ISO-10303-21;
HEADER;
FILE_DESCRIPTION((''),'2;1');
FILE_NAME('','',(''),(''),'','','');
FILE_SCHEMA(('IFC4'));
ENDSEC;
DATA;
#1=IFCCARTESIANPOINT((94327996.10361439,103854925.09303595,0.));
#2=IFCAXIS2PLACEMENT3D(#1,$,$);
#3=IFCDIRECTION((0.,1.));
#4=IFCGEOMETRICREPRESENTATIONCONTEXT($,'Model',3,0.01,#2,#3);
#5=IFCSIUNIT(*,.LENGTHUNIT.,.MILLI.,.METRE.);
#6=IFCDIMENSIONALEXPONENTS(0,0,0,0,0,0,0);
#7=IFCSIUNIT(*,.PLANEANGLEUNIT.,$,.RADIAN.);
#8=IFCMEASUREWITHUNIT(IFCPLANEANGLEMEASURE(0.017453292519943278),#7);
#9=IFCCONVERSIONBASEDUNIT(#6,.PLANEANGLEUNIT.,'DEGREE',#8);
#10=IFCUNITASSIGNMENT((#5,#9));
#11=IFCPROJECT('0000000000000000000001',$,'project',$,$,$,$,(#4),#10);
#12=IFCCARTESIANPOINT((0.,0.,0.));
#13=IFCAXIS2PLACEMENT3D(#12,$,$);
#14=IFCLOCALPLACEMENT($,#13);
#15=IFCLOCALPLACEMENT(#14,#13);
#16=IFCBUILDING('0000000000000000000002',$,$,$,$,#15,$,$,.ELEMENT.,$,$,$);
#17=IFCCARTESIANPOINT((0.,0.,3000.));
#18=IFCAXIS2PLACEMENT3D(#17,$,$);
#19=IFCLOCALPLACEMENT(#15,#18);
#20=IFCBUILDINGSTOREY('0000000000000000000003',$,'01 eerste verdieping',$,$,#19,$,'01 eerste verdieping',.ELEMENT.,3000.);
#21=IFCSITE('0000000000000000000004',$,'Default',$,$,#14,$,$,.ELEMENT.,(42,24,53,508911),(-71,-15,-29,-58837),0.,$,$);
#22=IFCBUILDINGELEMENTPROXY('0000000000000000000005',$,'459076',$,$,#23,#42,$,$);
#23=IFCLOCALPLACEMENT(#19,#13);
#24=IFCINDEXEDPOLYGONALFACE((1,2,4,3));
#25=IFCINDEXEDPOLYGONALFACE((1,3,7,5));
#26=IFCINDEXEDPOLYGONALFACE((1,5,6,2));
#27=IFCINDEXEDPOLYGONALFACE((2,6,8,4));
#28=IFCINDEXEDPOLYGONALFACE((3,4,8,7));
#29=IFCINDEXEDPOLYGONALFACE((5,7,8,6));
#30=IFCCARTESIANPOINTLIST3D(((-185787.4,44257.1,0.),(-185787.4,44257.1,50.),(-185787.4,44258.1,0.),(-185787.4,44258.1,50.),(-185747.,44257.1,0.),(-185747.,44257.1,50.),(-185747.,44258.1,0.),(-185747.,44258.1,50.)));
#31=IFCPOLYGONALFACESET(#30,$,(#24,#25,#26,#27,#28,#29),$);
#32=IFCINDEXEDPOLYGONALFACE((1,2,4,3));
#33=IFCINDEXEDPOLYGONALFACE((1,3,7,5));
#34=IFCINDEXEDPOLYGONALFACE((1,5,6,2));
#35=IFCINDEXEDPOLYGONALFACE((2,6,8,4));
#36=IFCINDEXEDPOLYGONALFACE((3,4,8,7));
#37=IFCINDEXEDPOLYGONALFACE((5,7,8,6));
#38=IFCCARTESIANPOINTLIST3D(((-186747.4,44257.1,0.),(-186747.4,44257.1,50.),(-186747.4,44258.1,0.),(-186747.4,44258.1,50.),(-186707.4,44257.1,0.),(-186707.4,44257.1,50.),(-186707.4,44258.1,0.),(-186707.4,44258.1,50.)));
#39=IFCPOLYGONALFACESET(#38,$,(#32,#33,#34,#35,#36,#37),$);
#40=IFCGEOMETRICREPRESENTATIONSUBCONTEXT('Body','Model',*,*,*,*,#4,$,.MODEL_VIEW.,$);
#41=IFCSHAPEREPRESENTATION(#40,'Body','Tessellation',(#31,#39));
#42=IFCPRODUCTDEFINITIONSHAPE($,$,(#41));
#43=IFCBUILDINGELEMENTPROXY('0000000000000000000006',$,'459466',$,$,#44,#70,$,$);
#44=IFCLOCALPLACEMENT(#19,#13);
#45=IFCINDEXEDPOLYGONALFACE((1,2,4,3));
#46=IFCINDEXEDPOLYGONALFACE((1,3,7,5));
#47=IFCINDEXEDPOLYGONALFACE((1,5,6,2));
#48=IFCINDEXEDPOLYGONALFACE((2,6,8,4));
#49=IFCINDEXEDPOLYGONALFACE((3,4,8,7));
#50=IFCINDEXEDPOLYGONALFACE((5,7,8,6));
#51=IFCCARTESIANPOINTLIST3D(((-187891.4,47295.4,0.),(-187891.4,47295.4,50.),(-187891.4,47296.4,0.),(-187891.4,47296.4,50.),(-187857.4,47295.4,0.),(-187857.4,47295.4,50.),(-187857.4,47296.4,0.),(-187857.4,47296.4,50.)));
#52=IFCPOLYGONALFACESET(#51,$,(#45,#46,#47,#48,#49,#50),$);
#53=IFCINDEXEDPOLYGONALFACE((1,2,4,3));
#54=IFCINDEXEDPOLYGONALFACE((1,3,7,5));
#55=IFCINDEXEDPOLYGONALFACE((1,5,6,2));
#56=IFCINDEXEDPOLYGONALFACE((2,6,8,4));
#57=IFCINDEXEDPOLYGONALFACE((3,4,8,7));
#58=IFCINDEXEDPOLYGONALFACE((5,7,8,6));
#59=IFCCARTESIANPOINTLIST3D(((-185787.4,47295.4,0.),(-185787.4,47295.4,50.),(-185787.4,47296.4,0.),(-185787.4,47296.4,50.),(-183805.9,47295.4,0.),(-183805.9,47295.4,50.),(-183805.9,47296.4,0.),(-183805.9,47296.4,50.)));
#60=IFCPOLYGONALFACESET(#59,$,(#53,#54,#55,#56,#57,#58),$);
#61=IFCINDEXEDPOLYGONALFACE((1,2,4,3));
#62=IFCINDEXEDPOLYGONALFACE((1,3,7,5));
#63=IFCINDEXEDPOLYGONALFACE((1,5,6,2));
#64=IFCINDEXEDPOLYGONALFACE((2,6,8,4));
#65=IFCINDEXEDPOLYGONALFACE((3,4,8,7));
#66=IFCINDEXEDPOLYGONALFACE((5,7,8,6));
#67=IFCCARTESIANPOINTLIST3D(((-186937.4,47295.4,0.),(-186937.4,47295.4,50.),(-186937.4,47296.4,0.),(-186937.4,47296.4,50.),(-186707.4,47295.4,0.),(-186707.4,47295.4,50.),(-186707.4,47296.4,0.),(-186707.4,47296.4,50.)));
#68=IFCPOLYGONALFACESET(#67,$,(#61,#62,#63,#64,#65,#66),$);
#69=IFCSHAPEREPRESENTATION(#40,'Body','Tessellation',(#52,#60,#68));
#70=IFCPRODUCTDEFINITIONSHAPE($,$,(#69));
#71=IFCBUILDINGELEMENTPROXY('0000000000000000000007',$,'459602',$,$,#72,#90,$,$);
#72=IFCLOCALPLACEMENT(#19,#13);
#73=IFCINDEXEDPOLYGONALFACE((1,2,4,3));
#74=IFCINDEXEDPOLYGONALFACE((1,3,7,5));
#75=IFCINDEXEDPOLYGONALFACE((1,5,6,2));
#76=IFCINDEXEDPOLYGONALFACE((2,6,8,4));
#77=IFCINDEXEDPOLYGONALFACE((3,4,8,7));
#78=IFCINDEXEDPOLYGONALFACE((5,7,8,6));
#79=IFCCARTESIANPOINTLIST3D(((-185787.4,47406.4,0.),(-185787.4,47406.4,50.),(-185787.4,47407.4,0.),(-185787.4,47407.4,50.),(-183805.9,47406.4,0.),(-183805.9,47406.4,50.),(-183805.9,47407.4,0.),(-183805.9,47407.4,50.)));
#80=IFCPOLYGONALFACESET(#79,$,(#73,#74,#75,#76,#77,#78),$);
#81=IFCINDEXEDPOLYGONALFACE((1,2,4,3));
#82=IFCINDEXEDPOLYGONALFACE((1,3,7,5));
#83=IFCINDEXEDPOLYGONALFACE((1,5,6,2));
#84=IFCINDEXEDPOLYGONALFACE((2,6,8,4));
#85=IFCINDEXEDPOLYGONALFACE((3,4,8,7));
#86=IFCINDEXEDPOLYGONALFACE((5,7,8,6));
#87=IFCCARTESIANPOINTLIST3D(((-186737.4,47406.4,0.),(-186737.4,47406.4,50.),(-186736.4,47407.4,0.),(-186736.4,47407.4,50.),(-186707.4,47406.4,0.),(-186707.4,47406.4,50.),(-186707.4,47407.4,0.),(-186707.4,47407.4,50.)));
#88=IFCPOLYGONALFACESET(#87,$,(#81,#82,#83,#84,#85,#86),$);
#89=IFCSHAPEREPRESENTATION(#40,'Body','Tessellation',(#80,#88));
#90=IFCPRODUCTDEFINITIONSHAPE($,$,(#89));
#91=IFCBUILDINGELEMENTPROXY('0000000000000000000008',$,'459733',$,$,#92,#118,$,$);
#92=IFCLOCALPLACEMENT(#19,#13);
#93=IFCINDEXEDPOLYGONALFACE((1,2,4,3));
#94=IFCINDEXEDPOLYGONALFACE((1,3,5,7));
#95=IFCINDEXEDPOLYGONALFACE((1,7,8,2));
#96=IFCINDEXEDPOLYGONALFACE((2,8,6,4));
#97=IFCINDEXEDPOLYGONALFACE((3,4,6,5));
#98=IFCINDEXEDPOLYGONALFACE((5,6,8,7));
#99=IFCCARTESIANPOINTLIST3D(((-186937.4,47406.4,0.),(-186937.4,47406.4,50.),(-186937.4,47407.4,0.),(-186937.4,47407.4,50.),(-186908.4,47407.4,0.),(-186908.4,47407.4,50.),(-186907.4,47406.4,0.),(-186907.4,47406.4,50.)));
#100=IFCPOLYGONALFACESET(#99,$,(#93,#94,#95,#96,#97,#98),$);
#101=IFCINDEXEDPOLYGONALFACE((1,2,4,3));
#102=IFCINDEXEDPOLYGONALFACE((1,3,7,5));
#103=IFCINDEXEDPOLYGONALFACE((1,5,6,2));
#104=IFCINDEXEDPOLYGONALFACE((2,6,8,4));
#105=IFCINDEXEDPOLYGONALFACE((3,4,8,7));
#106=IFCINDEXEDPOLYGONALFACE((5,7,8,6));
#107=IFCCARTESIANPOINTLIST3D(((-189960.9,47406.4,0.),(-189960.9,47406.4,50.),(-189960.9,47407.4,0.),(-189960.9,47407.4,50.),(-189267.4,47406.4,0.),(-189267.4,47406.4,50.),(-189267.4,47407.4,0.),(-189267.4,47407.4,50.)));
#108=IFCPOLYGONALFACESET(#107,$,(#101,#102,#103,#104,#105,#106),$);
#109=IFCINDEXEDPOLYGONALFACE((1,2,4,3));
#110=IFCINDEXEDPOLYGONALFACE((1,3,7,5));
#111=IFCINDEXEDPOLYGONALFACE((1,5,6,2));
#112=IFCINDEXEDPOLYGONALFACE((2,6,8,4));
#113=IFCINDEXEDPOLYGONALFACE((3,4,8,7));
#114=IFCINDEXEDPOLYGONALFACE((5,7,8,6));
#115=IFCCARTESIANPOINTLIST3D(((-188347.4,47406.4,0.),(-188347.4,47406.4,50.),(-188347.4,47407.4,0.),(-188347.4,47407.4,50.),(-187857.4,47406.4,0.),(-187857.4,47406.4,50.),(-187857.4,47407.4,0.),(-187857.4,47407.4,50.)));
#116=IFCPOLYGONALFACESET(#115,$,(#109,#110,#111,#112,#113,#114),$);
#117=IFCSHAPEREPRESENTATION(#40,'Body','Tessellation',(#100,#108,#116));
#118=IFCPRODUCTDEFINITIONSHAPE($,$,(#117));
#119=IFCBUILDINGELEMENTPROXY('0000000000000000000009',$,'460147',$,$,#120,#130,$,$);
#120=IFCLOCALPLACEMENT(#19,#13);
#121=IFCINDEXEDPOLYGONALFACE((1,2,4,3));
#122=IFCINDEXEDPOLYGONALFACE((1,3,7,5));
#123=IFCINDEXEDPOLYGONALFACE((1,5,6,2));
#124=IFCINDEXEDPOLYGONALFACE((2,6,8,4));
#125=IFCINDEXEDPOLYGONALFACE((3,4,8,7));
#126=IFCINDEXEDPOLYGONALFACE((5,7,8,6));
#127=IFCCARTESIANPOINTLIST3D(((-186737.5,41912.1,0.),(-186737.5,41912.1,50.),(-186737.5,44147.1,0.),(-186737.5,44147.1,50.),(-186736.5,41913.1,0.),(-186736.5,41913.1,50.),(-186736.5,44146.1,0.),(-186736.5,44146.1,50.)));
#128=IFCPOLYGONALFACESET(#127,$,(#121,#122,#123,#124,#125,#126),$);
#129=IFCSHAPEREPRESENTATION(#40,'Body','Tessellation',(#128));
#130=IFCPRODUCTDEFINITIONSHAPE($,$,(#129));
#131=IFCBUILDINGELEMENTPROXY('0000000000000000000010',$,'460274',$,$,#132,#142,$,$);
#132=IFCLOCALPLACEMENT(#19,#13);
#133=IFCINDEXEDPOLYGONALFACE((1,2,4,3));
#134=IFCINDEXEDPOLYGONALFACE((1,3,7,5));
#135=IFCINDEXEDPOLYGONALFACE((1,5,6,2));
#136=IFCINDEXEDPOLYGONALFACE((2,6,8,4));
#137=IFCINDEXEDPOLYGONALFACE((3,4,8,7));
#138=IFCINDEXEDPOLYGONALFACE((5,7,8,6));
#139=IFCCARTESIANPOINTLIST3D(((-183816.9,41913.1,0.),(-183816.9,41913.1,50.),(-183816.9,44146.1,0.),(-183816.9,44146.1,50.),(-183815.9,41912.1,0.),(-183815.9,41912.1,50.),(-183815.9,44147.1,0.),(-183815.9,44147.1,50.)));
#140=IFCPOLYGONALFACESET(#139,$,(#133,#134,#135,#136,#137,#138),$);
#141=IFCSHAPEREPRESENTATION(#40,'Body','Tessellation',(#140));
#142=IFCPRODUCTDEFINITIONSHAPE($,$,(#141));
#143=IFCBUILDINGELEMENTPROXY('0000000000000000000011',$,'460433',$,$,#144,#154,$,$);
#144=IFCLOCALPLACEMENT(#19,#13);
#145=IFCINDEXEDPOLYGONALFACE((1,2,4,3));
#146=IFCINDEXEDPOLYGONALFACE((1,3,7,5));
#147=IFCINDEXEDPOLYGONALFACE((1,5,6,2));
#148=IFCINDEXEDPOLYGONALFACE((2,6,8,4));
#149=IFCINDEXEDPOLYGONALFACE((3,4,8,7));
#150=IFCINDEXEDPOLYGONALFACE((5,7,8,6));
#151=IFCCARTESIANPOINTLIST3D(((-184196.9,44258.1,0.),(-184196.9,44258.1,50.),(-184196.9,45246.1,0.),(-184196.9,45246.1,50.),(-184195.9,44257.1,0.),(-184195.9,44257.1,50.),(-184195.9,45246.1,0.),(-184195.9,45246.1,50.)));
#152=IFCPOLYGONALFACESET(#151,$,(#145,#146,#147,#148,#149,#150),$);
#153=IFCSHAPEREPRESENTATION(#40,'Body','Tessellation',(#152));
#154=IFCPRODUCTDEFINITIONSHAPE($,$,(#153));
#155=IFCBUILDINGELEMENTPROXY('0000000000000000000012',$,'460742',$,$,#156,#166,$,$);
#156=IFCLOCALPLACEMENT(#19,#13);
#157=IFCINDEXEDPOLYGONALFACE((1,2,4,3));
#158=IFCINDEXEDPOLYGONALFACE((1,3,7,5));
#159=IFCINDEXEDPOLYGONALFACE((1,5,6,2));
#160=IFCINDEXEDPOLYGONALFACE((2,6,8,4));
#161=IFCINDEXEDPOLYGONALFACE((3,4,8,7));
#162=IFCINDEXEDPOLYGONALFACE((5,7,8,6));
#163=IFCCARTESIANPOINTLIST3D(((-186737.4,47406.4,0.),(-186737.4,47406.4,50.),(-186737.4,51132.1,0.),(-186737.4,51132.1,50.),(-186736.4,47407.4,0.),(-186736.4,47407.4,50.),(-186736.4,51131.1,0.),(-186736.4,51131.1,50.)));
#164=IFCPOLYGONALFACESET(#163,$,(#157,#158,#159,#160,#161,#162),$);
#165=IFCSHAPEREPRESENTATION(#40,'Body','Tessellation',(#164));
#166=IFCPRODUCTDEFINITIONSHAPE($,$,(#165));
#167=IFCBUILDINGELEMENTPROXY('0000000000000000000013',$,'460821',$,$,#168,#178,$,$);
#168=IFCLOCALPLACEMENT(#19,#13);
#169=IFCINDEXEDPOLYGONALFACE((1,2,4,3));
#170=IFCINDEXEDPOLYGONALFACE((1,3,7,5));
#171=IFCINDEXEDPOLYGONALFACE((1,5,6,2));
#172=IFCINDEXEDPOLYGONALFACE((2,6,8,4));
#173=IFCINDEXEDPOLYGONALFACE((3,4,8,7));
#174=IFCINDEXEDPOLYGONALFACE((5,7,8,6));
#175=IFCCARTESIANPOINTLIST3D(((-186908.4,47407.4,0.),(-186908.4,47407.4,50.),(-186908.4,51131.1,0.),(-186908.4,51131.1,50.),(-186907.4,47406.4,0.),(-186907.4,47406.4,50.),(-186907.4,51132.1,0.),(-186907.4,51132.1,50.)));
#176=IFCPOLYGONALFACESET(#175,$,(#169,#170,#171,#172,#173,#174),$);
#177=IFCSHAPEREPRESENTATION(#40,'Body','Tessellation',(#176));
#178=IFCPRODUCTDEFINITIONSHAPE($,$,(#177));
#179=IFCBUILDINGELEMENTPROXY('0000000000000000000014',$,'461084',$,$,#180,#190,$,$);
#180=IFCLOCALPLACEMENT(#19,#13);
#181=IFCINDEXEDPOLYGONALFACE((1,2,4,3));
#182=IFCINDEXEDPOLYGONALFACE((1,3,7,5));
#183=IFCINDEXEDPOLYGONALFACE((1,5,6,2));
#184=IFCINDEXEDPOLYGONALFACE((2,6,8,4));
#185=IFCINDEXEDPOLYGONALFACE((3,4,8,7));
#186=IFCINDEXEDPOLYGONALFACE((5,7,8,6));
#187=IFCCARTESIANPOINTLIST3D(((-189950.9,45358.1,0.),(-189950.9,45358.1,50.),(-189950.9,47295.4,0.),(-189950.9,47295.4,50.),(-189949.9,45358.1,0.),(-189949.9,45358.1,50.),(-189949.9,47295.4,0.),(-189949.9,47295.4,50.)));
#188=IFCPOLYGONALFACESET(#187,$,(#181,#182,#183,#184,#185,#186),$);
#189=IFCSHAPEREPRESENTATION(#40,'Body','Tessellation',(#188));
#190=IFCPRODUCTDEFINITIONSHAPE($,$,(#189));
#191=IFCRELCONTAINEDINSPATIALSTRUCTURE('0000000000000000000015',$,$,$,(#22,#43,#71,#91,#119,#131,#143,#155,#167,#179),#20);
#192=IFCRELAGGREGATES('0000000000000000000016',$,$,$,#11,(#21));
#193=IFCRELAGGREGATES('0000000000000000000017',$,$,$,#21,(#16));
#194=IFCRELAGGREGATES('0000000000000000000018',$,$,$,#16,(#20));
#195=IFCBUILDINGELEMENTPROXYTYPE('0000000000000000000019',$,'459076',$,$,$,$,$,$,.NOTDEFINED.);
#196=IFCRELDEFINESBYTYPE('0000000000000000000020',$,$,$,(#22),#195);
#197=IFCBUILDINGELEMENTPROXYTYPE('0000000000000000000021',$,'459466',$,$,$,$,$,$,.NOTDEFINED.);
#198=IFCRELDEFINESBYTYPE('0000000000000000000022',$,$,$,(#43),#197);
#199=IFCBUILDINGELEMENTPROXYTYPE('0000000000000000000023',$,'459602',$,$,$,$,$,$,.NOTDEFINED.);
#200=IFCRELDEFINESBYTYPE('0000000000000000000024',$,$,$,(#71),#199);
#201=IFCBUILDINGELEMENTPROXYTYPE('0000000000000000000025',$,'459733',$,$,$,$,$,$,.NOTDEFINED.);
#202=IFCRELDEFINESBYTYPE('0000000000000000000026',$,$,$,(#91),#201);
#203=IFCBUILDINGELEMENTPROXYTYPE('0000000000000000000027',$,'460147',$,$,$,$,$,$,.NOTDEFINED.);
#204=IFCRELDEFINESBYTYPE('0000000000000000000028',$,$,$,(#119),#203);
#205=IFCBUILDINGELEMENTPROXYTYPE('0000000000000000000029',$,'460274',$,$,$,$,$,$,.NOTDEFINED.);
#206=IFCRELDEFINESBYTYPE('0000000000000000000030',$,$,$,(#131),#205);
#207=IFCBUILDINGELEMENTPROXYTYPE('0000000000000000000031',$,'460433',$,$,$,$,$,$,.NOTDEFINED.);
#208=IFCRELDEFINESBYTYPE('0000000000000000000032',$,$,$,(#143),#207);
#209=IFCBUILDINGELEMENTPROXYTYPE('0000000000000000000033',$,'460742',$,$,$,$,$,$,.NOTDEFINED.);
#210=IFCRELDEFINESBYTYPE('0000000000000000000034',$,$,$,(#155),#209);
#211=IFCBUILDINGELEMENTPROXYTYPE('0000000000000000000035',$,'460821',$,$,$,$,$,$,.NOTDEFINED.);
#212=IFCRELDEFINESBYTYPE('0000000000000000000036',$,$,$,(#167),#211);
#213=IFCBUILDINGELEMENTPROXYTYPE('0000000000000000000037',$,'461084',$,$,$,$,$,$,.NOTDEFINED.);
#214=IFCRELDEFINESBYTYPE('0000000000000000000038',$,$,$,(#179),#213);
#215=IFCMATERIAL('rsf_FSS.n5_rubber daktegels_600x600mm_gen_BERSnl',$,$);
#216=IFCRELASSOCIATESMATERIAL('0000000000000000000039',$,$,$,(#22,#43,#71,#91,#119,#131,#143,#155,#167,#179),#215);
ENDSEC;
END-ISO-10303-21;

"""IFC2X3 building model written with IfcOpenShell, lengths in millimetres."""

from ifc_helpers import new_model, entity, si_unit, converted_unit, direction, frame, frame_2d, origin, origin_2d_with_axis, place, context, subcontext, project, spatial, polyline, rectangle, outline, extrude, material, type_object, element, save


model = new_model("IFC2X3")

# Units and contexts
model_context = context("Model", 3, precision=0.01, world=frame((94327996.10361439, 103854925.09303595, 0.0)), true_north=direction((0.0, 1.0)))
body_context = subcontext(model_context, "Body", "Model", "MODEL_VIEW")
ifc_project = project(units=[si_unit("LENGTHUNIT", "METRE", prefix="MILLI"), converted_unit("PLANEANGLEUNIT", "DEGREE", entity("IfcPlaneAngleMeasure", 0.017453292519943278), si_unit("PLANEANGLEUNIT", "RADIAN"), dimensions=[0, 0, 0, 0, 0, 0, 0])], contexts=[model_context])

# Site, building, storey
site_placement = place(None, origin())
site = spatial("IfcSite", under=ifc_project, at=site_placement, Name="Default", CompositionType="ELEMENT", RefLatitude=(42, 24, 53, 508911), RefLongitude=(-71, -15, -29, -58837), RefElevation=0.0)
building_placement = place(site_placement, origin())
building = spatial("IfcBuilding", under=site, at=building_placement, CompositionType="ELEMENT")
storey_placement = place(building_placement, frame((0.0, 0.0, 3000.0)))
storey = spatial("IfcBuildingStorey", under=building, at=storey_placement, Name="01 eerste verdieping", LongName="01 eerste verdieping", CompositionType="ELEMENT", Elevation=3000.0)

# Building element proxies
ifc_material = material(Name="rsf_FSS.n5_rubber daktegels_600x600mm_gen_BERSnl")
building_element_proxy_type_1 = type_object("IfcBuildingElementProxyType", Name="459076", PredefinedType="NOTDEFINED")
proxy_1_placement = place(storey_placement, origin())
element("IfcBuildingElementProxy", 1, at=proxy_1_placement, inside=storey, type_object=building_element_proxy_type_1, material=ifc_material, Name="459076", context=body_context, shape_type="SweptSolid", body=[
    extrude(rectangle(XDim=40.4, YDim=1.0, at=frame_2d((0.0, 0.0), x_axis=(1.0, 0.0))), frame((-185767.2, 44257.6, 0.0)), (0.0, 0.0, 1.0), 50.0),
    extrude(rectangle(XDim=40.0, YDim=1.0, at=frame_2d((0.0, 0.0), x_axis=(1.0, 0.0))), frame((-186727.4, 44257.6, 0.0)), (0.0, 0.0, 1.0), 50.0),
])
building_element_proxy_type_2 = type_object("IfcBuildingElementProxyType", Name="459466", PredefinedType="NOTDEFINED")
proxy_2_placement = place(storey_placement, origin())
element("IfcBuildingElementProxy", 2, at=proxy_2_placement, inside=storey, type_object=building_element_proxy_type_2, material=ifc_material, Name="459466", context=body_context, shape_type="SweptSolid", body=[
    extrude(rectangle(XDim=34.0, YDim=1.0, at=frame_2d((0.0, 0.0), x_axis=(1.0, 0.0))), frame((-187874.4, 47295.9, 0.0), z_axis=(0.0, 0.0, 1.0), x_axis=(-1.0, 0.0, 0.0)), (0.0, 0.0, 1.0), 50.0),
    extrude(rectangle(XDim=1981.5, YDim=1.0, at=frame_2d((0.0, 0.0), x_axis=(1.0, 0.0))), frame((-184796.6, 47295.9, 0.0), z_axis=(0.0, 0.0, 1.0), x_axis=(-1.0, 0.0, 0.0)), (0.0, 0.0, 1.0), 50.0),
    extrude(rectangle(XDim=230.0, YDim=1.0, at=frame_2d((0.0, 0.0), x_axis=(1.0, 0.0))), frame((-186822.4, 47295.9, 0.0), z_axis=(0.0, 0.0, 1.0), x_axis=(-1.0, 0.0, 0.0)), (0.0, 0.0, 1.0), 50.0),
])
building_element_proxy_type_3 = type_object("IfcBuildingElementProxyType", Name="459602", PredefinedType="NOTDEFINED")
proxy_3_placement = place(storey_placement, origin())
element("IfcBuildingElementProxy", 3, at=proxy_3_placement, inside=storey, type_object=building_element_proxy_type_3, material=ifc_material, Name="459602", context=body_context, shape_type="SweptSolid", body=[
    extrude(rectangle(XDim=1981.5, YDim=1.0, at=frame_2d((0.0, 0.0), x_axis=(1.0, 0.0))), frame((-184796.6, 47406.9, 0.0)), (0.0, 0.0, 1.0), 50.0),
    extrude(outline(polyline([(-15.3, -0.5), (14.8, -0.5), (14.8, 0.5), (-14.3, 0.5), (-15.3, -0.5)])), frame((-186722.1, 47406.9, 0.0)), (0.0, 0.0, 1.0), 50.0),
])
building_element_proxy_type_4 = type_object("IfcBuildingElementProxyType", Name="459733", PredefinedType="NOTDEFINED")
proxy_4_placement = place(storey_placement, origin())
element("IfcBuildingElementProxy", 4, at=proxy_4_placement, inside=storey, type_object=building_element_proxy_type_4, material=ifc_material, Name="459733", context=body_context, shape_type="SweptSolid", body=[
    extrude(outline(polyline([(-14.7, -0.5), (15.2, -0.5), (14.2, 0.5), (-14.7, 0.5), (-14.7, -0.5)])), frame((-186922.6, 47406.9, 0.0)), (0.0, 0.0, 1.0), 50.0),
    extrude(rectangle(XDim=693.5, YDim=1.0, at=origin_2d_with_axis()), frame((-189614.1, 47406.9, 0.0)), (0.0, 0.0, 1.0), 50.0),
    extrude(rectangle(XDim=490.0, YDim=1.0, at=origin_2d_with_axis()), frame((-188102.4, 47406.9, 0.0)), (0.0, 0.0, 1.0), 50.0),
])
building_element_proxy_type_5 = type_object("IfcBuildingElementProxyType", Name="460147", PredefinedType="NOTDEFINED")
proxy_5_placement = place(storey_placement, origin())
element("IfcBuildingElementProxy", 5, at=proxy_5_placement, inside=storey, type_object=building_element_proxy_type_5, material=ifc_material, Name="460147", context=body_context, shape_type="SweptSolid", body=[
    extrude(outline(polyline([(-1117.5, -0.5), (1117.5, -0.5), (1116.5, 0.5), (-1116.5, 0.5), (-1117.5, -0.5)])), frame((-186737.0, 43029.6, 0.0), z_axis=(0.0, 0.0, 1.0), x_axis=(0.0, -1.0, 0.0)), (0.0, 0.0, 1.0), 50.0),
])
building_element_proxy_type_6 = type_object("IfcBuildingElementProxyType", Name="460274", PredefinedType="NOTDEFINED")
proxy_6_placement = place(storey_placement, origin())
element("IfcBuildingElementProxy", 6, at=proxy_6_placement, inside=storey, type_object=building_element_proxy_type_6, material=ifc_material, Name="460274", context=body_context, shape_type="SweptSolid", body=[
    extrude(outline(polyline([(-1117.5, -0.5), (1117.5, -0.5), (1116.5, 0.5), (-1116.5, 0.5), (-1117.5, -0.5)])), frame((-183816.4, 43029.6, 0.0), z_axis=(0.0, 0.0, 1.0), x_axis=(0.0, 1.0, 0.0)), (0.0, 0.0, 1.0), 50.0),
])
building_element_proxy_type_7 = type_object("IfcBuildingElementProxyType", Name="460433", PredefinedType="NOTDEFINED")
proxy_7_placement = place(storey_placement, origin())
element("IfcBuildingElementProxy", 7, at=proxy_7_placement, inside=storey, type_object=building_element_proxy_type_7, material=ifc_material, Name="460433", context=body_context, shape_type="SweptSolid", body=[
    extrude(outline(polyline([(-494.7, -0.5), (494.2, -0.5), (494.2, 0.5), (-493.7, 0.5), (-494.7, -0.5)])), frame((-184196.4, 44751.8, 0.0), z_axis=(0.0, 0.0, 1.0), x_axis=(0.0, 1.0, 0.0)), (0.0, 0.0, 1.0), 50.0),
])
building_element_proxy_type_8 = type_object("IfcBuildingElementProxyType", Name="460742", PredefinedType="NOTDEFINED")
proxy_8_placement = place(storey_placement, origin())
element("IfcBuildingElementProxy", 8, at=proxy_8_placement, inside=storey, type_object=building_element_proxy_type_8, material=ifc_material, Name="460742", context=body_context, shape_type="SweptSolid", body=[
    extrude(outline(polyline([(-1862.8, -0.5), (1862.8, -0.5), (1861.8, 0.5), (-1861.8, 0.5), (-1862.8, -0.5)])), frame((-186736.9, 49269.2, 0.0), z_axis=(0.0, 0.0, 1.0), x_axis=(0.0, -1.0, 0.0)), (0.0, 0.0, 1.0), 50.0),
])
building_element_proxy_type_9 = type_object("IfcBuildingElementProxyType", Name="460821", PredefinedType="NOTDEFINED")
proxy_9_placement = place(storey_placement, origin())
element("IfcBuildingElementProxy", 9, at=proxy_9_placement, inside=storey, type_object=building_element_proxy_type_9, material=ifc_material, Name="460821", context=body_context, shape_type="SweptSolid", body=[
    extrude(outline(polyline([(-1862.8, -0.5), (1862.8, -0.5), (1861.8, 0.5), (-1861.8, 0.5), (-1862.8, -0.5)])), frame((-186907.9, 49269.2, 0.0), z_axis=(0.0, 0.0, 1.0), x_axis=(0.0, 1.0, 0.0)), (0.0, 0.0, 1.0), 50.0),
])
building_element_proxy_type_10 = type_object("IfcBuildingElementProxyType", Name="461084", PredefinedType="NOTDEFINED")
proxy_10_placement = place(storey_placement, origin())
element("IfcBuildingElementProxy", 10, at=proxy_10_placement, inside=storey, type_object=building_element_proxy_type_10, material=ifc_material, Name="461084", context=body_context, shape_type="SweptSolid", body=[
    extrude(rectangle(XDim=1937.4, YDim=1.0, at=frame_2d((0.0, 0.0), x_axis=(1.0, 0.0))), frame((-189950.4, 46326.7, 0.0), z_axis=(0.0, 0.0, 1.0), x_axis=(0.0, -1.0, 0.0)), (0.0, 0.0, 1.0), 50.0),
])

save(model, "model.ifc")
